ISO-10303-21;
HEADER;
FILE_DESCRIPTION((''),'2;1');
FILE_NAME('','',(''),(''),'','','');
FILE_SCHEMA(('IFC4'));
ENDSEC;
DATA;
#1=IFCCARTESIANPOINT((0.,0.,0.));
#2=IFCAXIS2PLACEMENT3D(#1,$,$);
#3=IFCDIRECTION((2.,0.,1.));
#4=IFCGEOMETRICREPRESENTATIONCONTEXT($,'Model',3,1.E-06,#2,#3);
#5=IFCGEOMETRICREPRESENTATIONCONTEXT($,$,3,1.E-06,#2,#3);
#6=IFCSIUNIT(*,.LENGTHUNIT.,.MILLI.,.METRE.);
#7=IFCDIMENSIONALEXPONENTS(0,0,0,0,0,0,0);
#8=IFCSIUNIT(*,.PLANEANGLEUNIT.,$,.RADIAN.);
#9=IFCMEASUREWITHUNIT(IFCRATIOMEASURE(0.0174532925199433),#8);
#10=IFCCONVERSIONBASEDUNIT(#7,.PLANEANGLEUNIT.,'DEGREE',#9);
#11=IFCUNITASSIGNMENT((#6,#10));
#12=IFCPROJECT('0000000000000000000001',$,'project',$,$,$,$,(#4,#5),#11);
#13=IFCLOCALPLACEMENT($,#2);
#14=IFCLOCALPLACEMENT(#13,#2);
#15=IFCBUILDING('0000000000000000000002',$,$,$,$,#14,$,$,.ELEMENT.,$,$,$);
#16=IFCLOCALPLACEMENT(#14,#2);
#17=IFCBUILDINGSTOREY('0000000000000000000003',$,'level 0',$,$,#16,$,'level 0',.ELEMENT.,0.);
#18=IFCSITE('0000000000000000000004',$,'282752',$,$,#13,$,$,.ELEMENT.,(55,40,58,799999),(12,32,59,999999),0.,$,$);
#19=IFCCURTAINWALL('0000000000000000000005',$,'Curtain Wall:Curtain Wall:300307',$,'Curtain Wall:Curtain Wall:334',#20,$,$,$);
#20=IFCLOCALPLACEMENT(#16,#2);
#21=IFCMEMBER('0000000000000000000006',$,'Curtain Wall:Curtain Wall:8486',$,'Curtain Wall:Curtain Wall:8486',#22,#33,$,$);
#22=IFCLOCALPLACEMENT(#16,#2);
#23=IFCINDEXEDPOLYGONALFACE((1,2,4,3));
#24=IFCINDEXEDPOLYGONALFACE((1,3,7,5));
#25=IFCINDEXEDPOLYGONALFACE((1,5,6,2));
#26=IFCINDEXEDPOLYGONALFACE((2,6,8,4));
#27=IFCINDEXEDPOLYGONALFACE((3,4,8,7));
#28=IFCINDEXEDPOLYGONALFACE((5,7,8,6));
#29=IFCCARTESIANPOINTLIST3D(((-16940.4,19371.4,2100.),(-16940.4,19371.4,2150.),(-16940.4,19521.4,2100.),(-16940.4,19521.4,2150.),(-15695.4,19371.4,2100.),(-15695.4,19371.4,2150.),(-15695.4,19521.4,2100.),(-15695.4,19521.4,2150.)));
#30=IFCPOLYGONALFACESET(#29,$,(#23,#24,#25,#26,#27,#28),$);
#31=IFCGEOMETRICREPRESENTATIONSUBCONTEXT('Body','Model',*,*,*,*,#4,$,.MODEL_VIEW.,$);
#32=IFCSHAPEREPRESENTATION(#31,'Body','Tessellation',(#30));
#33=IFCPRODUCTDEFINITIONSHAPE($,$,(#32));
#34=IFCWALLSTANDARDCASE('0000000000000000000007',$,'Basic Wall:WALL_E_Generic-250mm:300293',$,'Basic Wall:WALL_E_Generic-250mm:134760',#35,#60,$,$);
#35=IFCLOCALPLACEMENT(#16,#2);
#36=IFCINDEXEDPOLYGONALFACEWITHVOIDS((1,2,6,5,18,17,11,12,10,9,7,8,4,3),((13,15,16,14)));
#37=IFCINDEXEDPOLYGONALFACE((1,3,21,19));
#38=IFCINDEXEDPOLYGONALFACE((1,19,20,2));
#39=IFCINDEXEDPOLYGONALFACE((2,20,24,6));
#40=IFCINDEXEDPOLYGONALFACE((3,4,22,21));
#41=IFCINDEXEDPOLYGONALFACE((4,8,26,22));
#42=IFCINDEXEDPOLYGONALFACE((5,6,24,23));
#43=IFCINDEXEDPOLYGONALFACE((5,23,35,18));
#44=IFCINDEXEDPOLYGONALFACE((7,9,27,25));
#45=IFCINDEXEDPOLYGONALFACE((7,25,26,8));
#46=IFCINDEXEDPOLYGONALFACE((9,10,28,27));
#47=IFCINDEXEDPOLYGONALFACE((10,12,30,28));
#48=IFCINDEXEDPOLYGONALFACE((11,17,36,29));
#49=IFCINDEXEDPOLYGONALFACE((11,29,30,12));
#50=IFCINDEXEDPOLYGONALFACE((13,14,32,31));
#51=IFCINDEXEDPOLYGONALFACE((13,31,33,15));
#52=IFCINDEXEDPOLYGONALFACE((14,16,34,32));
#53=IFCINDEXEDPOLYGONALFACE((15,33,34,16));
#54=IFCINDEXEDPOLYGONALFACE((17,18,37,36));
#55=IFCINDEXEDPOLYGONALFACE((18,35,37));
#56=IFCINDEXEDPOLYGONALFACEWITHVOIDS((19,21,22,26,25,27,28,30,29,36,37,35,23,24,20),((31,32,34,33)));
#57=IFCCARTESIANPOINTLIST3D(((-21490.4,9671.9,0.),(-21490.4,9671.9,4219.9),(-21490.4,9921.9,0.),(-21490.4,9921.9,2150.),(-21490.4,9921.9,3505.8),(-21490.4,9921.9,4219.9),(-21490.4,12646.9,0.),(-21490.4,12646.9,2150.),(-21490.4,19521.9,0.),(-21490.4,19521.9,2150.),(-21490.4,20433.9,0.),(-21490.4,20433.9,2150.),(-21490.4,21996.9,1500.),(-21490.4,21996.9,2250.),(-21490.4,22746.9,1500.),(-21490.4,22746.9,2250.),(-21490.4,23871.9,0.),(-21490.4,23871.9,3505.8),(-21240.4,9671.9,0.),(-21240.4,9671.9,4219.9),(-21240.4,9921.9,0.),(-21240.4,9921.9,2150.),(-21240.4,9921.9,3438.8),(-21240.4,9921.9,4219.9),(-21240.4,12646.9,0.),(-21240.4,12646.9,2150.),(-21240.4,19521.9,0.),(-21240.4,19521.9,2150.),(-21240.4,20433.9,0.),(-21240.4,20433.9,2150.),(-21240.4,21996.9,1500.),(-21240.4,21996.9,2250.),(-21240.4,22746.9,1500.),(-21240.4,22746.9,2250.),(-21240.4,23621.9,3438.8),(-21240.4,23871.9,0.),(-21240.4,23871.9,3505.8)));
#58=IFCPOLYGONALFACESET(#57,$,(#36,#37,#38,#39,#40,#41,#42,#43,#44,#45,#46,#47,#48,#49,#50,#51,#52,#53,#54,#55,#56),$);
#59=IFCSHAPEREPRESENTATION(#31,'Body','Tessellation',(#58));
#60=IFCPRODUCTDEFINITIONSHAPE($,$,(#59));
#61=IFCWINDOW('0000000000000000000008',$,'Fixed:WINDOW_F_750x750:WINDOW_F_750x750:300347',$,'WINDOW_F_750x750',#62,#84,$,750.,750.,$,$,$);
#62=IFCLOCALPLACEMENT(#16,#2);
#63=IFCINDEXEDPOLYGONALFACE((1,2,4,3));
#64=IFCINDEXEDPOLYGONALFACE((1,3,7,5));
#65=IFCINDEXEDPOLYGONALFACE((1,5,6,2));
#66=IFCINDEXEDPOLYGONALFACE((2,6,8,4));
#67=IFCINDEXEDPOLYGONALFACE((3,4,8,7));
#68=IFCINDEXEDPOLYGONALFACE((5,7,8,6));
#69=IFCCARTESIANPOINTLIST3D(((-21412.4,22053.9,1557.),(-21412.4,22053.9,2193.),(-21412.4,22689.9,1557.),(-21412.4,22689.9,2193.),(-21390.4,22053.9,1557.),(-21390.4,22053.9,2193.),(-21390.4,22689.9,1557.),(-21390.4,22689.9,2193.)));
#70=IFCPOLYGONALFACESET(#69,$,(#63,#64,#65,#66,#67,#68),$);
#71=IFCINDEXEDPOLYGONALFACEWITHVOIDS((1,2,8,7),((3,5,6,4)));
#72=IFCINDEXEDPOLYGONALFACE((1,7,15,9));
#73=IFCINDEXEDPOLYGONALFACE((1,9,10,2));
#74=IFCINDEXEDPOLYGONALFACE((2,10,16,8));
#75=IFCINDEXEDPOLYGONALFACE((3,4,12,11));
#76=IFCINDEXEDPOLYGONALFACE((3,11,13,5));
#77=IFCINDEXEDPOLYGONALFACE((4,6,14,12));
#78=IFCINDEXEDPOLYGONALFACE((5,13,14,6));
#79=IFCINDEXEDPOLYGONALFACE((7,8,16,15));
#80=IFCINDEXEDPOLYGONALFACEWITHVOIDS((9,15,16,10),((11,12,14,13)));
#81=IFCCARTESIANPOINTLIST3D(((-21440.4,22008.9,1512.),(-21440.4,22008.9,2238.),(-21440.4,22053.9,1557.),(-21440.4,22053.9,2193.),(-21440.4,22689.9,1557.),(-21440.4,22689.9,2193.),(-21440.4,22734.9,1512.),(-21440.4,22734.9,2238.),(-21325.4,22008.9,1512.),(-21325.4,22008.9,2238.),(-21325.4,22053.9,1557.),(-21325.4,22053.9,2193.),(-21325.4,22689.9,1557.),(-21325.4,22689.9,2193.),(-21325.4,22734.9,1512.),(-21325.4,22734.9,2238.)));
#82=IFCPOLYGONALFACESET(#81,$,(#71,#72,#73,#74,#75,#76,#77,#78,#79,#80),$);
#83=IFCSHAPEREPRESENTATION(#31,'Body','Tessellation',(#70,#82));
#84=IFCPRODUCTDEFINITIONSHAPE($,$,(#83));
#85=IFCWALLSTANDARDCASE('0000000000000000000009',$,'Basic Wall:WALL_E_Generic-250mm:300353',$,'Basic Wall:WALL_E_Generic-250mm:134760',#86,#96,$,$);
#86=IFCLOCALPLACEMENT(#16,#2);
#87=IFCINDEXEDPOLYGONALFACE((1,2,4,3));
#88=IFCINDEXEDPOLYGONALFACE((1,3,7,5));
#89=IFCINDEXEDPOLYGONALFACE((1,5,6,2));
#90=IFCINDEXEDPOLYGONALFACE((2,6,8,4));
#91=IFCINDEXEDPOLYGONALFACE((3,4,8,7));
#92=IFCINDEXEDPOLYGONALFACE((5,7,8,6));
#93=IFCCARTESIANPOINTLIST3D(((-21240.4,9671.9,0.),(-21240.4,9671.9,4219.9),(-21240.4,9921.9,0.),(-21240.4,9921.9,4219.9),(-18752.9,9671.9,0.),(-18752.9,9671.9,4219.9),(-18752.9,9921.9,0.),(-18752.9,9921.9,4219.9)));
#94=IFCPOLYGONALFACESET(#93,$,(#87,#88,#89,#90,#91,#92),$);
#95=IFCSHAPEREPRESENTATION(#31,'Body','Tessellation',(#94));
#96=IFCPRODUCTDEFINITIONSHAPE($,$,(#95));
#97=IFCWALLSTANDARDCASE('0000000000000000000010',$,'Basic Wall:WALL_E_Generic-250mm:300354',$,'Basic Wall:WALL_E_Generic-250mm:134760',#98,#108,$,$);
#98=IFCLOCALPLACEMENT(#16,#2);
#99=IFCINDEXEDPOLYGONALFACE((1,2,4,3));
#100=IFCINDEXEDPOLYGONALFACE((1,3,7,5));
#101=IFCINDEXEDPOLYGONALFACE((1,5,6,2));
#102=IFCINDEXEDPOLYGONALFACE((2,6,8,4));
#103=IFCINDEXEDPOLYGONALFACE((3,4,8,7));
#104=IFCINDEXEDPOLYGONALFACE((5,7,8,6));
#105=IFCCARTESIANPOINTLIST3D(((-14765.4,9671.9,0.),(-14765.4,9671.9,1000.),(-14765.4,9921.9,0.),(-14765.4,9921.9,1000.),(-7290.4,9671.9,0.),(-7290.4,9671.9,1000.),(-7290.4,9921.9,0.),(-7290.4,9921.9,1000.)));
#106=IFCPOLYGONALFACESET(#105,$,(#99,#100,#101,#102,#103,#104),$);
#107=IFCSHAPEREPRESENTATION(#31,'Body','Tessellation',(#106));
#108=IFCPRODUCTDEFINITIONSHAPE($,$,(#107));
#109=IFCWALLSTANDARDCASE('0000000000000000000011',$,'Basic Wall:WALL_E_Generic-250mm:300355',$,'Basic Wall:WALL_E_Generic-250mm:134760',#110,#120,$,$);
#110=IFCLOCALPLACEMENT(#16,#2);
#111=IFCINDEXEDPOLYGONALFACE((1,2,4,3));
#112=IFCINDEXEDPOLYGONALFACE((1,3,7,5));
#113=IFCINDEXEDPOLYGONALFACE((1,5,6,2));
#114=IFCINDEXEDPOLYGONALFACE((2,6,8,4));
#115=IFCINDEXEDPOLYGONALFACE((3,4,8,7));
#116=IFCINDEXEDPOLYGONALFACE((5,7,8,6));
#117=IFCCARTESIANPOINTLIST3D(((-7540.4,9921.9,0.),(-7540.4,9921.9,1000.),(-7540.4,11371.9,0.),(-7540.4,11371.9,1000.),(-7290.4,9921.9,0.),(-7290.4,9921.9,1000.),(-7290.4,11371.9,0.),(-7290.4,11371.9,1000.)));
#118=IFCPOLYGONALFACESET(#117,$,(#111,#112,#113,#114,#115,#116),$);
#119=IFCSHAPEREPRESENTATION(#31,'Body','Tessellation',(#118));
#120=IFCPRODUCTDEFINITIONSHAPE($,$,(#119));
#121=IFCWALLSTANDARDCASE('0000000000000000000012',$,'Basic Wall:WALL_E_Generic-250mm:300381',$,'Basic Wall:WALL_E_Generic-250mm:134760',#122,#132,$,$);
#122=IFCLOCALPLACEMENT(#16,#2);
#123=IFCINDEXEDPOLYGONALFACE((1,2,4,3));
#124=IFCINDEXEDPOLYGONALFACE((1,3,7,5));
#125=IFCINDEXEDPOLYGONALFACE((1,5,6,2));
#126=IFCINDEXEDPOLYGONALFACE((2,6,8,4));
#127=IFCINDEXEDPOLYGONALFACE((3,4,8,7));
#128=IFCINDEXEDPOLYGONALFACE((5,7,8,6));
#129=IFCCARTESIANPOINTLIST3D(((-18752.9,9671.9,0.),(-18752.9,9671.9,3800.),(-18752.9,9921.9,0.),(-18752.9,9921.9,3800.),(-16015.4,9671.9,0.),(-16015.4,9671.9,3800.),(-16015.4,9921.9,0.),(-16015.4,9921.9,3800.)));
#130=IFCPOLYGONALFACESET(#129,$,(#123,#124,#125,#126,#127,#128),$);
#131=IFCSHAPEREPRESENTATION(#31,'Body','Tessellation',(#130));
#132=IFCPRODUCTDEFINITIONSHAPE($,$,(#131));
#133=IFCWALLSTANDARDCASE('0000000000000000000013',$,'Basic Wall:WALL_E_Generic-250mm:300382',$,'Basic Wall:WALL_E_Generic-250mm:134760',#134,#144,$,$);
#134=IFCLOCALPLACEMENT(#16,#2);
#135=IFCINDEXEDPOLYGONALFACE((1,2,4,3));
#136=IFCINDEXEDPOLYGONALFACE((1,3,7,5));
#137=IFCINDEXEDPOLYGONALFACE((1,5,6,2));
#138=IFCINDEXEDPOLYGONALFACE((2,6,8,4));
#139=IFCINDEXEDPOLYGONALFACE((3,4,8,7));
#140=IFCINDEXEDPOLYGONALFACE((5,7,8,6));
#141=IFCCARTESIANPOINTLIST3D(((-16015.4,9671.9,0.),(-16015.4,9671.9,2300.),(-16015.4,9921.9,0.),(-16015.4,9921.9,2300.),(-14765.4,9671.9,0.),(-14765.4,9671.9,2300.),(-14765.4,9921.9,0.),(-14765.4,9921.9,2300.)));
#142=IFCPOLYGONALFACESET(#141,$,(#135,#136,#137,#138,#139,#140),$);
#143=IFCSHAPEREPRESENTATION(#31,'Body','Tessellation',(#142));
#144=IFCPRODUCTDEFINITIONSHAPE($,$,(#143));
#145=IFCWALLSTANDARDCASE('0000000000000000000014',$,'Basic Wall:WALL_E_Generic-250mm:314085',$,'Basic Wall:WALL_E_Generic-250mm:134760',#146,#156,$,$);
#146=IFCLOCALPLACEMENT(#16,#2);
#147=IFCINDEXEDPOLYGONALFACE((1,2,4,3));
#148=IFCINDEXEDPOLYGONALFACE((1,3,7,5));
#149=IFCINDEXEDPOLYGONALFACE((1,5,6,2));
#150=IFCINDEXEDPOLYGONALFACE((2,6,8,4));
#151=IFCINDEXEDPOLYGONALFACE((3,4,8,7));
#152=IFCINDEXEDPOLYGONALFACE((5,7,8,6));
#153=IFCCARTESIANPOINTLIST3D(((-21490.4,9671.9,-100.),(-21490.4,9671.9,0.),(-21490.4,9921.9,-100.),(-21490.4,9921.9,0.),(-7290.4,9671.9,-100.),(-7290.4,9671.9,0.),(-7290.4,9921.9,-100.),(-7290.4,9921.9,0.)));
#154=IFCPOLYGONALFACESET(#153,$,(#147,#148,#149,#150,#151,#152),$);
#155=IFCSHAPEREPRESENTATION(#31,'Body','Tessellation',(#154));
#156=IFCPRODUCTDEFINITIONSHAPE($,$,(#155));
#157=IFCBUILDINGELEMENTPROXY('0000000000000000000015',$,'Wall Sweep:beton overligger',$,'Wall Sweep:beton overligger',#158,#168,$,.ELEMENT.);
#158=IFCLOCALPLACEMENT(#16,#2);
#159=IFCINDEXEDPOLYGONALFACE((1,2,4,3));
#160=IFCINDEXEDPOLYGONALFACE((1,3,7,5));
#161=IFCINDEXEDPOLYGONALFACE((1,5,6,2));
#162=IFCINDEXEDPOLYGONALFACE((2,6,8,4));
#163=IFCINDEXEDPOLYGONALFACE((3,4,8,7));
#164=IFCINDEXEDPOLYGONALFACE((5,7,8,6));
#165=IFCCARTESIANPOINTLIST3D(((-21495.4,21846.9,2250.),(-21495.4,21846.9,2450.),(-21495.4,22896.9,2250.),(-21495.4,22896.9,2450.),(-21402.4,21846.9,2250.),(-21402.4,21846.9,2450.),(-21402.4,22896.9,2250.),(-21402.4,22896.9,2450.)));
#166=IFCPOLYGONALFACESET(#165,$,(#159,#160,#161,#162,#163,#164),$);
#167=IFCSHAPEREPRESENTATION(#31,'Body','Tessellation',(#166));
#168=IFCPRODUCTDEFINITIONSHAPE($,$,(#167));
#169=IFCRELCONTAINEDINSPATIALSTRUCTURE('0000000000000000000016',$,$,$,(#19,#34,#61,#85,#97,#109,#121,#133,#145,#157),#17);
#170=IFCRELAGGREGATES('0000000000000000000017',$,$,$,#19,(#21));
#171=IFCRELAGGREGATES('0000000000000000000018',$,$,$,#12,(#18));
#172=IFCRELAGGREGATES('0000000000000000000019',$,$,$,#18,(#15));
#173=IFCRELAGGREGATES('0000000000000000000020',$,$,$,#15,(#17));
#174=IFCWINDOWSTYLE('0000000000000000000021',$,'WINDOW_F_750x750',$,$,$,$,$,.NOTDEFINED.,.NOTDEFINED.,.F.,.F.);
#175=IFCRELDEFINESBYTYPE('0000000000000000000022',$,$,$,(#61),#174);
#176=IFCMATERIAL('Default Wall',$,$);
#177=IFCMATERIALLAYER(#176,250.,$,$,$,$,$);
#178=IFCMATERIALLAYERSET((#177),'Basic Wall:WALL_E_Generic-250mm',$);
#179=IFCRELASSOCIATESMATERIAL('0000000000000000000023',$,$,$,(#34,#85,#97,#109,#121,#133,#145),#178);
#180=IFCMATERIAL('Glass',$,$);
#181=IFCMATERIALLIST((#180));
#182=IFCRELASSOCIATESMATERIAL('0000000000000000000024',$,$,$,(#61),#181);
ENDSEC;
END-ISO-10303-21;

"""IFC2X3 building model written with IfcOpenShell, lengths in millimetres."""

from ifc_helpers import new_model, entity, si_unit, converted_unit, direction, frame, frame_2d, origin, origin_2d_with_axis, place, context, subcontext, project, spatial, polyline, rectangle, outline, extrude, clip, bounded_halfspace, source, transform, mapped, material, material_list, layer, layer_set, layer_usage, type_object, type_shapes, element, fill, aggregate, save


model = new_model("IFC2X3")

# Units and contexts
model_context = context("Model", 3, precision=1e-06, world=origin(), true_north=direction((2.0, 0.0, 1.0)))
context_of_model = context(None, 3, precision=1e-06, world=origin(), true_north=direction((2.0, 0.0, 1.0)))
body_context = subcontext(model_context, "Body", "Model", "MODEL_VIEW")
ifc_project = project(units=[si_unit("LENGTHUNIT", "METRE", prefix="MILLI"), converted_unit("PLANEANGLEUNIT", "DEGREE", entity("IfcRatioMeasure", 0.0174532925199433), si_unit("PLANEANGLEUNIT", "RADIAN"), dimensions=[0, 0, 0, 0, 0, 0, 0])], contexts=[model_context, context_of_model])

# Site, building, storey
site_placement = place(None, origin())
site = spatial("IfcSite", under=ifc_project, at=site_placement, Name="282752", CompositionType="ELEMENT", RefLatitude=(55, 40, 58, 799999), RefLongitude=(12, 32, 59, 999999), RefElevation=0.0)
building_placement = place(site_placement, origin())
building = spatial("IfcBuilding", under=site, at=building_placement, CompositionType="ELEMENT")
storey_placement = place(building_placement, origin())
storey = spatial("IfcBuildingStorey", under=building, at=storey_placement, Name="level 0", LongName="level 0", CompositionType="ELEMENT", Elevation=0.0)

# Curtain wall, member
curtain_wall_placement = place(storey_placement, origin())
curtain_wall = element("IfcCurtainWall", 1, at=curtain_wall_placement, inside=storey, Name="Curtain Wall:Curtain Wall:300307", ObjectType="Curtain Wall:Curtain Wall:334")
member_1_placement = place(storey_placement, origin())
member_1 = element("IfcMember", 2, at=member_1_placement, Name="Curtain Wall:Curtain Wall:8486", ObjectType="Curtain Wall:Curtain Wall:8486", context=body_context, shape_type="SweptSolid", body=[
    extrude(rectangle(XDim=1245.0, YDim=150.0, at=frame_2d((0.0, 0.0), x_axis=(1.0, 0.0))), frame((-16317.9, 19446.4, 2100.0)), (0.0, 0.0, 1.0), 50.0),
])
aggregate(curtain_wall, [member_1])

# Wall, openings, window
ifc_material_1 = material(Name="Default Wall")
ifc_layer_1 = layer(ifc_material_1, 250.0)
ifc_layer_set_1 = layer_set([ifc_layer_1], Name="Basic Wall:WALL_E_Generic-250mm")
ifc_layer_usage_1 = layer_usage(ifc_layer_set_1, "AXIS2", "NEGATIVE", 125.0)
wall_1_placement = place(storey_placement, frame((-21365.4, 9671.9, 0.0), z_axis=(0.0, 0.0, 1.0), x_axis=(0.0, 1.0, 0.0)))
wall_1 = element("IfcWallStandardCase", 3, at=wall_1_placement, inside=storey, material=ifc_layer_usage_1, Name="Basic Wall:WALL_E_Generic-250mm:300293", ObjectType="Basic Wall:WALL_E_Generic-250mm:134760", context=body_context, shape_type="Clipping", body=[
    clip(clip(extrude(rectangle(XDim=14200.0, YDim=250.0, at=frame_2d((7100.0, 0.0), x_axis=(-1.0, 0.0))), origin(), (0.0, 0.0, 1.0), 4219.9), bounded_halfspace(frame((14200.0, 125.0, 3505.8), z_axis=(0.0, -0.258819, 0.965926), x_axis=(1.0, 0.0, 0.0)), False, frame((14200.0, 125.0, 3505.8)), polyline([(0.0, 0.0), (-13950.0, 0.0), (-13950.0, -250.0), (-11350.0, -250.0), (-11100.0, -250.0), (-8375.0, -250.0), (-8275.0, -250.0), (-4475.0, -250.0), (-4375.0, -250.0), (-3413.0, -250.0), (-3313.0, -250.0), (-250.0, -250.0), (0.0, 0.0)]))), bounded_halfspace(frame((14200.0, -125.0, 3505.8), z_axis=(-0.258819, 0.0, 0.965926), x_axis=(0.0, -1.0, 0.0)), False, frame((14200.0, -125.0, 3505.8)), polyline([(0.0, 0.0), (0.0, 250.0), (-250.0, 0.0), (0.0, 0.0)]))),
])
opening_1_placement = place(wall_1_placement, origin())
element("IfcOpeningElement", 4, at=opening_1_placement, cuts=wall_1, ObjectType="Recess", context=body_context, shape_type="SweptSolid", body=[
    extrude(rectangle(XDim=2356.7, YDim=2725.0, at=origin_2d_with_axis()), frame((1612.5, -125.0, 971.7), z_axis=(0.0, 1.0, 0.0), x_axis=(0.0, 0.0, -1.0)), (0.0, 0.0, 1.0), 250.0),
])
opening_2_placement = place(wall_1_placement, frame((12325.0, -125.0, 1500.0)))
opening_2 = element("IfcOpeningElement", 5, at=opening_2_placement, cuts=wall_1, ObjectType="Opening", context=body_context, shape_type="SweptSolid", body=[
    extrude(rectangle(XDim=750.0, YDim=750.0, at=frame_2d((375.0, 375.0), x_axis=(1.0, 0.0))), frame((0.0, 0.0, 0.0), z_axis=(0.0, 1.0, 0.0), x_axis=(0.0, 0.0, 1.0)), (0.0, 0.0, 1.0), 250.0),
])
opening_3_placement = place(wall_1_placement, frame((10762.0, 125.0, 0.0)))
element("IfcOpeningElement", 6, at=opening_3_placement, cuts=wall_1, ObjectType="Opening", context=body_context, shape_type="SweptSolid", body=[
    extrude(rectangle(XDim=2150.0, YDim=912.0, at=frame_2d((1075.0, 456.0), x_axis=(1.0, 0.0))), frame((0.0, 0.0, 0.0), z_axis=(0.0, -1.0, 0.0), x_axis=(0.0, 0.0, 1.0)), (0.0, 0.0, 1.0), 250.0),
])
ifc_material_2 = material(Name="Glass")
ifc_material_list = material_list([ifc_material_2])
window_style = type_object("IfcWindowStyle", Name="WINDOW_F_750x750", ConstructionType="NOTDEFINED", OperationType="NOTDEFINED", ParameterTakesPrecedence=False, Sizeable=False)
shared_shape = source(origin(), body_context, "Body", "SweptSolid", [
    extrude(rectangle(XDim=636.0, YDim=22.0, at=origin_2d_with_axis()), frame((375.0, 161.0, 57.0), z_axis=(0.0, 0.0, 1.0), x_axis=(-1.0, 0.0, 0.0)), (0.0, 0.0, 1.0), 636.0),
    extrude(outline(polyline([(-363.0, -363.0), (363.0, -363.0), (363.0, 363.0), (-363.0, 363.0), (-363.0, -363.0)]), holes=[polyline([(318.0, -318.0), (-318.0, -318.0), (-318.0, 318.0), (318.0, 318.0), (318.0, -318.0)])]), frame((375.0, 85.0, 375.0), z_axis=(0.0, 1.0, 0.0), x_axis=(0.0, 0.0, 1.0)), (0.0, 0.0, 1.0), 115.0),
])
type_shapes(window_style, [shared_shape])
window_placement = place(opening_2_placement, origin())
window = element("IfcWindow", 7, at=window_placement, inside=storey, type_object=window_style, material=ifc_material_list, Name="Fixed:WINDOW_F_750x750:WINDOW_F_750x750:300347", ObjectType="WINDOW_F_750x750", OverallHeight=750.0, OverallWidth=750.0, context=body_context, shape_type="MappedRepresentation", body=[
    mapped(shared_shape, transform((0.0, 0.0, 0.0), scale=1.0)),
])
fill(opening_2, window)

# Walls
ifc_layer_usage_2 = layer_usage(ifc_layer_set_1, "AXIS2", "POSITIVE", -125.0)
wall_2_placement = place(storey_placement, frame((-21240.4, 9796.9, 0.0)))
element("IfcWallStandardCase", 8, at=wall_2_placement, inside=storey, material=ifc_layer_usage_2, Name="Basic Wall:WALL_E_Generic-250mm:300353", ObjectType="Basic Wall:WALL_E_Generic-250mm:134760", context=body_context, shape_type="SweptSolid", body=[
    extrude(rectangle(XDim=2487.5, YDim=250.0, at=frame_2d((1243.8, 0.0), x_axis=(-1.0, 0.0))), origin(), (0.0, 0.0, 1.0), 4219.9),
])
ifc_layer_usage_3 = layer_usage(ifc_layer_set_1, "AXIS2", "NEGATIVE", 125.0)
wall_3_placement = place(storey_placement, frame((-7290.4, 9796.9, 0.0), z_axis=(0.0, 0.0, 1.0), x_axis=(-1.0, 0.0, 0.0)))
element("IfcWallStandardCase", 9, at=wall_3_placement, inside=storey, material=ifc_layer_usage_3, Name="Basic Wall:WALL_E_Generic-250mm:300354", ObjectType="Basic Wall:WALL_E_Generic-250mm:134760", context=body_context, shape_type="SweptSolid", body=[
    extrude(rectangle(XDim=7475.0, YDim=250.0, at=frame_2d((3737.5, 0.0), x_axis=(-1.0, 0.0))), origin(), (0.0, 0.0, 1.0), 1000.0),
])
ifc_layer_usage_4 = layer_usage(ifc_layer_set_1, "AXIS2", "NEGATIVE", 125.0)
wall_4_placement = place(storey_placement, frame((-7415.4, 9921.9, 0.0), z_axis=(0.0, 0.0, 1.0), x_axis=(0.0, 1.0, 0.0)))
element("IfcWallStandardCase", 10, at=wall_4_placement, inside=storey, material=ifc_layer_usage_4, Name="Basic Wall:WALL_E_Generic-250mm:300355", ObjectType="Basic Wall:WALL_E_Generic-250mm:134760", context=body_context, shape_type="SweptSolid", body=[
    extrude(rectangle(XDim=1450.0, YDim=250.0, at=frame_2d((725.0, 0.0), x_axis=(-1.0, 0.0))), origin(), (0.0, 0.0, 1.0), 1000.0),
])
ifc_layer_usage_5 = layer_usage(ifc_layer_set_1, "AXIS2", "POSITIVE", -125.0)
wall_5_placement = place(storey_placement, frame((-18752.9, 9796.9, 0.0)))
element("IfcWallStandardCase", 11, at=wall_5_placement, inside=storey, material=ifc_layer_usage_5, Name="Basic Wall:WALL_E_Generic-250mm:300381", ObjectType="Basic Wall:WALL_E_Generic-250mm:134760", context=body_context, shape_type="SweptSolid", body=[
    extrude(rectangle(XDim=2737.5, YDim=250.0, at=frame_2d((1368.8, 0.0), x_axis=(-1.0, 0.0))), origin(), (0.0, 0.0, 1.0), 3800.0),
])
ifc_layer_usage_6 = layer_usage(ifc_layer_set_1, "AXIS2", "POSITIVE", -125.0)
wall_6_placement = place(storey_placement, frame((-16015.4, 9796.9, 0.0)))
element("IfcWallStandardCase", 12, at=wall_6_placement, inside=storey, material=ifc_layer_usage_6, Name="Basic Wall:WALL_E_Generic-250mm:300382", ObjectType="Basic Wall:WALL_E_Generic-250mm:134760", context=body_context, shape_type="SweptSolid", body=[
    extrude(rectangle(XDim=1250.0, YDim=250.0, at=frame_2d((625.0, 0.0), x_axis=(-1.0, 0.0))), origin(), (0.0, 0.0, 1.0), 2300.0),
])
ifc_layer_usage_7 = layer_usage(ifc_layer_set_1, "AXIS2", "NEGATIVE", 125.0)
wall_7_placement = place(storey_placement, frame((-21490.4, 9796.9, -100.0)))
element("IfcWallStandardCase", 13, at=wall_7_placement, inside=storey, material=ifc_layer_usage_7, Name="Basic Wall:WALL_E_Generic-250mm:314085", ObjectType="Basic Wall:WALL_E_Generic-250mm:134760", context=body_context, shape_type="SweptSolid", body=[
    extrude(rectangle(XDim=14200.0, YDim=250.0, at=frame_2d((7100.0, 0.0), x_axis=(-1.0, 0.0))), origin(), (0.0, 0.0, 1.0), 100.0),
])

# Building element proxy
proxy_1_placement = place(storey_placement, origin())
element("IfcBuildingElementProxy", 14, at=proxy_1_placement, inside=storey, Name="Wall Sweep:beton overligger", ObjectType="Wall Sweep:beton overligger", CompositionType="ELEMENT", context=body_context, shape_type="SweptSolid", body=[
    extrude(rectangle(XDim=1050.0, YDim=93.0, at=frame_2d((0.0, 0.0), x_axis=(1.0, 0.0))), frame((-21448.9, 22371.9, 2250.0), z_axis=(0.0, 0.0, 1.0), x_axis=(0.0, 1.0, 0.0)), (0.0, 0.0, 1.0), 200.0),
])

save(model, "model.ifc")
